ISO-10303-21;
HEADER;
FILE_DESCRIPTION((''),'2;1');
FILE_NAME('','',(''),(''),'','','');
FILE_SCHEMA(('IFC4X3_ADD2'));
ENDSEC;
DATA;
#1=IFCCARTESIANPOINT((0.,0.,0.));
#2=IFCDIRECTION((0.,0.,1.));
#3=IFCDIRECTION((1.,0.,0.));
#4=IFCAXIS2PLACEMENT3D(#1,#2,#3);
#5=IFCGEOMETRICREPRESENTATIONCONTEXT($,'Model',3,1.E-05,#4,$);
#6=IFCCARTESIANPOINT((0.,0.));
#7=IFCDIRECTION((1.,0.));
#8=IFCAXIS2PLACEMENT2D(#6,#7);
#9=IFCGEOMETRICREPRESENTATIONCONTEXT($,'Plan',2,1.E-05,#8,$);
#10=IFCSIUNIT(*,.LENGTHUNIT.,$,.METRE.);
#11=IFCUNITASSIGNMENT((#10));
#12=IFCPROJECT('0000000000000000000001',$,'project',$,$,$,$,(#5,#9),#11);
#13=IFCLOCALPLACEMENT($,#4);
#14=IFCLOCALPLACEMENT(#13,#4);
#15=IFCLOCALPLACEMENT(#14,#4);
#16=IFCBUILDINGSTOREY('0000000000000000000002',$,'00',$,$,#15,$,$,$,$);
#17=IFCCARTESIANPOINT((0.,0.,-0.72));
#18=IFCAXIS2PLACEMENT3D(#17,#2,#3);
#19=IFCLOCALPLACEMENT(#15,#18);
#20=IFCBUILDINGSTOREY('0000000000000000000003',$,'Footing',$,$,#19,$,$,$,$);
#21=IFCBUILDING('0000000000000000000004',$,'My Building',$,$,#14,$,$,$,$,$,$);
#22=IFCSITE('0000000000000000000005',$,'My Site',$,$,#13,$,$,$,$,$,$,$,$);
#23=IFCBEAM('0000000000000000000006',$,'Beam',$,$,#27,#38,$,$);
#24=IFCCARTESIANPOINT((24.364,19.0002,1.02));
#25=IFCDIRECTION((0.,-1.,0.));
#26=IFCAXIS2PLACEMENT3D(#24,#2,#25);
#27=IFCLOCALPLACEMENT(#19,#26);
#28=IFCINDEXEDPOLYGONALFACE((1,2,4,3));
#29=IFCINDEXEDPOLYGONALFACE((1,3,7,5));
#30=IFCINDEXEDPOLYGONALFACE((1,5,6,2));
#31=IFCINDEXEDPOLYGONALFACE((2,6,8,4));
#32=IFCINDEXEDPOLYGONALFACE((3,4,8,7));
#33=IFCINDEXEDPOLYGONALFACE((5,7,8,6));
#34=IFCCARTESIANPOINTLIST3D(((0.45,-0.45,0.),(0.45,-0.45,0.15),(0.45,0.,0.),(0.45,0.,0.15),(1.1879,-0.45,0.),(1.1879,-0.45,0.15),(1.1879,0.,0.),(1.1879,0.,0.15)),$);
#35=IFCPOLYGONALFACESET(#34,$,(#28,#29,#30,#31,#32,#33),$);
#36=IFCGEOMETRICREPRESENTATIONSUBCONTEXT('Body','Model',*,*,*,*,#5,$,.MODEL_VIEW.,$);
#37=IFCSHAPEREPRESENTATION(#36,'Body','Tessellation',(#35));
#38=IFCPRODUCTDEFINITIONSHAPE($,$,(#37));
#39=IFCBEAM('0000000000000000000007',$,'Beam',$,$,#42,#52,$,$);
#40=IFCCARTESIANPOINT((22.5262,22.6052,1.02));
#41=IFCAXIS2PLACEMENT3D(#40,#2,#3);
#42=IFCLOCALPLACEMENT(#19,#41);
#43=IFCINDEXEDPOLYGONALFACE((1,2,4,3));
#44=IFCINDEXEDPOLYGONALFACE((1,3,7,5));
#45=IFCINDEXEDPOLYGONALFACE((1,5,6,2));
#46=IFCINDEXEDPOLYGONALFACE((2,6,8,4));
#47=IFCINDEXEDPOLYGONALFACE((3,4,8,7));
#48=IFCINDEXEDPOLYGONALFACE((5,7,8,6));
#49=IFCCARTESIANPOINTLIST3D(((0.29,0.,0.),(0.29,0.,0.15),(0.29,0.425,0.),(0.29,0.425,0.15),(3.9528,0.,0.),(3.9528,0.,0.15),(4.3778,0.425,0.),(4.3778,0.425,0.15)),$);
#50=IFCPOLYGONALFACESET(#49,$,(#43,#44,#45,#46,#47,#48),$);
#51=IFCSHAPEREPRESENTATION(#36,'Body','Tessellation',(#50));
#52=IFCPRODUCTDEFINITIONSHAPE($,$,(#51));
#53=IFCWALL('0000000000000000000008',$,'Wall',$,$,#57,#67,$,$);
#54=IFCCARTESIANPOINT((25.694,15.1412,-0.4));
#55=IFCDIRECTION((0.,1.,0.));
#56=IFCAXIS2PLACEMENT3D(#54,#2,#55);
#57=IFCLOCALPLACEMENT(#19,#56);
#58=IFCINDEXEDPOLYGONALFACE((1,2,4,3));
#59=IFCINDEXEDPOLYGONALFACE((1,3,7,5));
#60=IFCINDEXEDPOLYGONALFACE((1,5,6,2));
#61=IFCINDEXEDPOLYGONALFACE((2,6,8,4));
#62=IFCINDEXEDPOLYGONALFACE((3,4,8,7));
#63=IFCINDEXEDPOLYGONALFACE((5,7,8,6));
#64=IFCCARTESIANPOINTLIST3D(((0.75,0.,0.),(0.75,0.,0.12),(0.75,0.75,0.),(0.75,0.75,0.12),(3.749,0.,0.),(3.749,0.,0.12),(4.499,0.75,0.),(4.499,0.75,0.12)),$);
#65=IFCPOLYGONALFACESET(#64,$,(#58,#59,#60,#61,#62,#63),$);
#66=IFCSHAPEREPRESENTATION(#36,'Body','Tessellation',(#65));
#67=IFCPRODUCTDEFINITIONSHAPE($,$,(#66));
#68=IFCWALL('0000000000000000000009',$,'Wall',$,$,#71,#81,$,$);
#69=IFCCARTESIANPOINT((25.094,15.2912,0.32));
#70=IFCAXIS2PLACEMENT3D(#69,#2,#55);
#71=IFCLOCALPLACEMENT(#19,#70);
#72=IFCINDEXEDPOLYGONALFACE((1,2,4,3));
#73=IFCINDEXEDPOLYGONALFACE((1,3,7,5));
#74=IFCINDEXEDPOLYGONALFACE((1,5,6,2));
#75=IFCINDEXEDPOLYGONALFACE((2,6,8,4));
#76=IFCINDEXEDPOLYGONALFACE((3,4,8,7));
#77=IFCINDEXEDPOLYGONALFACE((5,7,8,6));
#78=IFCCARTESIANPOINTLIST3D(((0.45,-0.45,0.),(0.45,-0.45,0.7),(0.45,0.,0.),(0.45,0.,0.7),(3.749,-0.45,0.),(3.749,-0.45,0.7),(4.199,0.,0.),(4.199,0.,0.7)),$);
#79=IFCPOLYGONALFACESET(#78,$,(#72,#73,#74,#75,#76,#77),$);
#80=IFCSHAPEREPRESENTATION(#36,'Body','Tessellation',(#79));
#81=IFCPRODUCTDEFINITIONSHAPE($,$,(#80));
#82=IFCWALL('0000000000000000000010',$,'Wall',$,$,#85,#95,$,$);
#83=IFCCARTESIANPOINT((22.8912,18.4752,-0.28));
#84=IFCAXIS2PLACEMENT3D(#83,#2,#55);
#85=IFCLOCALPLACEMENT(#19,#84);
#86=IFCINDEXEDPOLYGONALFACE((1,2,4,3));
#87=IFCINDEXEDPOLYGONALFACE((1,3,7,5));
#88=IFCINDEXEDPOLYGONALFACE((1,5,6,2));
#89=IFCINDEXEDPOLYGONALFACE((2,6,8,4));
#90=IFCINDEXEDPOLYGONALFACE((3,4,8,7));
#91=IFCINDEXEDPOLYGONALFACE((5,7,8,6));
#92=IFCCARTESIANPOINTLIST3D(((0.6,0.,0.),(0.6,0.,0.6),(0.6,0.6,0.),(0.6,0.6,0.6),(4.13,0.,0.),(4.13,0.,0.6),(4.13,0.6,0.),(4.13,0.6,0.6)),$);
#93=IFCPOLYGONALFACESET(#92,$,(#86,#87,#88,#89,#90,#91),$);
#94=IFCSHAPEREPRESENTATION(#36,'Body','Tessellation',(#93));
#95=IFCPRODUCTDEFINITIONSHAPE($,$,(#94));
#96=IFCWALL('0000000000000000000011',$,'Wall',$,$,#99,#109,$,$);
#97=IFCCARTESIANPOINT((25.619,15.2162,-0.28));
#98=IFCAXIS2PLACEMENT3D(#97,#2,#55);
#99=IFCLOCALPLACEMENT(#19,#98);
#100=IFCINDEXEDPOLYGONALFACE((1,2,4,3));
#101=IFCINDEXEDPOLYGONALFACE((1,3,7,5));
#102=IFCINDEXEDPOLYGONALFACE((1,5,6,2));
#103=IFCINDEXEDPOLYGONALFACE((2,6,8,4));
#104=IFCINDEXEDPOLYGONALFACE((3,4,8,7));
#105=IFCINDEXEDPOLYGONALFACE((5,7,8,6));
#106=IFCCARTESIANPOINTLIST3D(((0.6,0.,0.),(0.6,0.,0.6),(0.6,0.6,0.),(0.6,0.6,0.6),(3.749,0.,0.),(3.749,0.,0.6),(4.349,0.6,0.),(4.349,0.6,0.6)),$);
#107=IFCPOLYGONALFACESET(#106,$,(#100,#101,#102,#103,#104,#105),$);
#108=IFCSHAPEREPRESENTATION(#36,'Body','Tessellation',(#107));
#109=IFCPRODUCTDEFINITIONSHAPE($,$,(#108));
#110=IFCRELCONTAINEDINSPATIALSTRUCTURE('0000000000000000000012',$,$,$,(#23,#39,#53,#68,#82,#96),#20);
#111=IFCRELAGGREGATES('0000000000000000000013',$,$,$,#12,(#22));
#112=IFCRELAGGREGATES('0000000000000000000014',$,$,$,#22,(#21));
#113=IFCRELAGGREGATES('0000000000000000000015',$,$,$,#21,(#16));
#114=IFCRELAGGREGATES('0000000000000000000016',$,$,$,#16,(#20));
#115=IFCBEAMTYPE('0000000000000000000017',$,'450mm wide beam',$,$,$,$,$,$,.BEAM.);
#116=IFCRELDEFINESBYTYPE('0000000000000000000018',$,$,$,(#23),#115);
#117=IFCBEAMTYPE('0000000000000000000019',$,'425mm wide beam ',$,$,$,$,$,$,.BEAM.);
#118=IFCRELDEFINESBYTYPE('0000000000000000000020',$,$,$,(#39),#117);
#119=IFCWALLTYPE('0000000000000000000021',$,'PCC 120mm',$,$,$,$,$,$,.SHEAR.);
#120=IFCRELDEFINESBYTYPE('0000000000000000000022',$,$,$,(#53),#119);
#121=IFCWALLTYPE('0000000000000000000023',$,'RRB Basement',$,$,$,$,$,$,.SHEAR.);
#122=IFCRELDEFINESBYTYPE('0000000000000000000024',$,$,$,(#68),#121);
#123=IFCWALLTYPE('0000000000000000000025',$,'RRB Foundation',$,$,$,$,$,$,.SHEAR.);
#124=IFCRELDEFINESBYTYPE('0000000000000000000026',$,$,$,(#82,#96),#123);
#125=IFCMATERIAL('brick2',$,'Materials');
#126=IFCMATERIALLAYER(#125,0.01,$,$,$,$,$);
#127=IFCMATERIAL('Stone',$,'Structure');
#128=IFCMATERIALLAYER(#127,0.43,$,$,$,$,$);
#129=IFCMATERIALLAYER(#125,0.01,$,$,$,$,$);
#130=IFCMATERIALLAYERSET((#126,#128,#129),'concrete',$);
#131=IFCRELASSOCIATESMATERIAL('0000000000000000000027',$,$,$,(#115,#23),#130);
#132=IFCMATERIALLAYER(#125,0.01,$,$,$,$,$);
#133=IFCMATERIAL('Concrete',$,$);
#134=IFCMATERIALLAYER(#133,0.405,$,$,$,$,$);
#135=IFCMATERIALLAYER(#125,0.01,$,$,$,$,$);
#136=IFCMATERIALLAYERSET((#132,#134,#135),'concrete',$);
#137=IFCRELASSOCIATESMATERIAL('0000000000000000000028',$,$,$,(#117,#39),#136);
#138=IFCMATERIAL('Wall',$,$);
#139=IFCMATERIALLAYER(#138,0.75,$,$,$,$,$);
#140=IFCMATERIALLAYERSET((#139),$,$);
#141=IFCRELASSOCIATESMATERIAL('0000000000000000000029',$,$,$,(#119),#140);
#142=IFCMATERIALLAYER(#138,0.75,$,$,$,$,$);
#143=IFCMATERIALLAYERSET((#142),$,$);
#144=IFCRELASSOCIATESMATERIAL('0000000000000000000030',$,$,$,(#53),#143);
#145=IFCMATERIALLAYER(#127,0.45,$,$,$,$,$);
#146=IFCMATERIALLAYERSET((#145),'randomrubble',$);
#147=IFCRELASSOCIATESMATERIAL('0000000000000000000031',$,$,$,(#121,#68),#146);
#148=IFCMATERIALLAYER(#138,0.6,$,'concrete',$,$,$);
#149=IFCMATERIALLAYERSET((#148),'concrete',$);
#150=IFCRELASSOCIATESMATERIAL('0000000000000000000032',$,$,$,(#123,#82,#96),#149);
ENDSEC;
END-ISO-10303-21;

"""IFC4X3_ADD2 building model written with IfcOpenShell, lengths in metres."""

from ifc_helpers import new_model, si_unit, frame, origin_with_axes, origin_2d_with_axis, place, context, subcontext, project, spatial, line, indexed_curve, outline, extrude, material, layer, layer_set, layer_usage, type_object, element, save


model = new_model("IFC4X3_ADD2")

# Units and contexts
model_context = context("Model", 3, precision=1e-05, world=origin_with_axes())
plan_context = context("Plan", 2, precision=1e-05, world=origin_2d_with_axis())
body_context = subcontext(model_context, "Body", "Model", "MODEL_VIEW")
ifc_project = project(units=[si_unit("LENGTHUNIT", "METRE")], contexts=[model_context, plan_context])

# Site, building, storeys
site_placement = place(None, origin_with_axes())
site = spatial("IfcSite", under=ifc_project, at=site_placement, Name="My Site")
building_placement = place(site_placement, origin_with_axes())
building = spatial("IfcBuilding", under=site, at=building_placement, Name="My Building")
storey_1_placement = place(building_placement, origin_with_axes())
storey_1 = spatial("IfcBuildingStorey", under=building, at=storey_1_placement, Name="00")
storey_2_placement = place(storey_1_placement, frame((0.0, 0.0, -0.72), z_axis=(0.0, 0.0, 1.0), x_axis=(1.0, 0.0, 0.0)))
storey_2 = spatial("IfcBuildingStorey", under=storey_1, at=storey_2_placement, Name="Footing")

# Beams
ifc_material_1 = material(Name="Wall")
ifc_material_2 = material(Name="brick2", Category="Materials")
ifc_layer_1 = layer(ifc_material_2, 0.01)
ifc_material_3 = material(Name="Stone", Category="Structure")
ifc_layer_2 = layer(ifc_material_3, 0.43)
ifc_layer_3 = layer(ifc_material_2, 0.01)
ifc_layer_set_1 = layer_set([ifc_layer_1, ifc_layer_2, ifc_layer_3], Name="concrete")
beam_type_1 = type_object("IfcBeamType", Name="450mm wide beam", PredefinedType="BEAM", material=ifc_layer_set_1)
ifc_layer_usage_1 = layer_usage(ifc_layer_set_1, "AXIS2", "NEGATIVE", 0.0)
beam_1_placement = place(storey_2_placement, frame((24.364, 19.0002, 1.02), z_axis=(0.0, 0.0, 1.0), x_axis=(0.0, -1.0, 0.0)))
element("IfcBeam", 1, at=beam_1_placement, inside=storey_2, type_object=beam_type_1, material=ifc_layer_usage_1, Name="Beam", context=body_context, shape_type="SweptSolid", body=[
    extrude(outline(indexed_curve([(0.45, -0.45), (0.45, 0.0), (1.1879, 0.0), (1.1879, -0.45)], segments=[line(1, 2, 3, 4, 1)])), origin_with_axes(), (0.0, 0.0, 1.0), 0.15),
])
ifc_layer_4 = layer(ifc_material_2, 0.01)
ifc_material_4 = material(Name="Concrete")
ifc_layer_5 = layer(ifc_material_4, 0.405)
ifc_layer_6 = layer(ifc_material_2, 0.01)
ifc_layer_set_2 = layer_set([ifc_layer_4, ifc_layer_5, ifc_layer_6], Name="concrete")
beam_type_2 = type_object("IfcBeamType", Name="425mm wide beam ", PredefinedType="BEAM", material=ifc_layer_set_2)
ifc_layer_usage_2 = layer_usage(ifc_layer_set_2, "AXIS2", "POSITIVE", 0.0)
beam_2_placement = place(storey_2_placement, frame((22.5262, 22.6052, 1.02), z_axis=(0.0, 0.0, 1.0), x_axis=(1.0, 0.0, 0.0)))
element("IfcBeam", 2, at=beam_2_placement, inside=storey_2, type_object=beam_type_2, material=ifc_layer_usage_2, Name="Beam", context=body_context, shape_type="SweptSolid", body=[
    extrude(outline(indexed_curve([(0.29, 0.0), (0.29, 0.425), (4.3778, 0.425), (3.9528, 0.0)], segments=[line(1, 2, 3, 4, 1)])), origin_with_axes(), (0.0, 0.0, 1.0), 0.15),
])

# Walls
ifc_layer_7 = layer(ifc_material_1, 0.75)
ifc_layer_set_3 = layer_set([ifc_layer_7])
wall_type_1 = type_object("IfcWallType", Name="PCC 120mm", PredefinedType="SHEAR", material=ifc_layer_set_3)
ifc_layer_8 = layer(ifc_material_1, 0.75)
ifc_layer_set_4 = layer_set([ifc_layer_8])
ifc_layer_usage_3 = layer_usage(ifc_layer_set_4, "AXIS2", "POSITIVE", 0.0)
wall_1_placement = place(storey_2_placement, frame((25.694, 15.1412, -0.4), z_axis=(0.0, 0.0, 1.0), x_axis=(0.0, 1.0, 0.0)))
element("IfcWall", 3, at=wall_1_placement, inside=storey_2, type_object=wall_type_1, material=ifc_layer_usage_3, Name="Wall", context=body_context, shape_type="SweptSolid", body=[
    extrude(outline(indexed_curve([(0.75, 0.0), (0.75, 0.75), (4.499, 0.75), (3.749, 0.0)], segments=[line(1, 2, 3, 4, 1)])), origin_with_axes(), (0.0, 0.0, 1.0), 0.12),
])
ifc_layer_9 = layer(ifc_material_3, 0.45)
ifc_layer_set_5 = layer_set([ifc_layer_9], Name="randomrubble")
ifc_layer_usage_4 = layer_usage(ifc_layer_set_5, "AXIS2", "NEGATIVE", 0.0)
wall_type_2 = type_object("IfcWallType", Name="RRB Basement", PredefinedType="SHEAR", material=ifc_layer_set_5)
wall_2_placement = place(storey_2_placement, frame((25.094, 15.2912, 0.32), z_axis=(0.0, 0.0, 1.0), x_axis=(0.0, 1.0, 0.0)))
element("IfcWall", 4, at=wall_2_placement, inside=storey_2, type_object=wall_type_2, material=ifc_layer_usage_4, Name="Wall", context=body_context, shape_type="SweptSolid", body=[
    extrude(outline(indexed_curve([(0.45, -0.45), (0.45, 0.0), (4.199, 0.0), (3.749, -0.45)], segments=[line(1, 2, 3, 4, 1)])), origin_with_axes(), (0.0, 0.0, 1.0), 0.7),
])
ifc_layer_10 = layer(ifc_material_1, 0.6, Name="concrete")
ifc_layer_set_6 = layer_set([ifc_layer_10], Name="concrete")
wall_type_3 = type_object("IfcWallType", Name="RRB Foundation", PredefinedType="SHEAR", material=ifc_layer_set_6)
ifc_layer_usage_5 = layer_usage(ifc_layer_set_6, "AXIS2", "POSITIVE", 0.0)
wall_3_placement = place(storey_2_placement, frame((22.8912, 18.4752, -0.28), z_axis=(0.0, 0.0, 1.0), x_axis=(0.0, 1.0, 0.0)))
element("IfcWall", 5, at=wall_3_placement, inside=storey_2, type_object=wall_type_3, material=ifc_layer_usage_5, Name="Wall", context=body_context, shape_type="SweptSolid", body=[
    extrude(outline(indexed_curve([(0.6, 0.0), (0.6, 0.6), (4.13, 0.6), (4.13, 0.0)], segments=[line(1, 2, 3, 4, 1)])), origin_with_axes(), (0.0, 0.0, 1.0), 0.6),
])
ifc_layer_usage_6 = layer_usage(ifc_layer_set_6, "AXIS2", "POSITIVE", 0.0)
wall_4_placement = place(storey_2_placement, frame((25.619, 15.2162, -0.28), z_axis=(0.0, 0.0, 1.0), x_axis=(0.0, 1.0, 0.0)))
element("IfcWall", 6, at=wall_4_placement, inside=storey_2, type_object=wall_type_3, material=ifc_layer_usage_6, Name="Wall", context=body_context, shape_type="SweptSolid", body=[
    extrude(outline(indexed_curve([(0.6, 0.0), (0.6, 0.6), (4.349, 0.6), (3.749, 0.0)], segments=[line(1, 2, 3, 4, 1)])), origin_with_axes(), (0.0, 0.0, 1.0), 0.6),
])

save(model, "model.ifc")
